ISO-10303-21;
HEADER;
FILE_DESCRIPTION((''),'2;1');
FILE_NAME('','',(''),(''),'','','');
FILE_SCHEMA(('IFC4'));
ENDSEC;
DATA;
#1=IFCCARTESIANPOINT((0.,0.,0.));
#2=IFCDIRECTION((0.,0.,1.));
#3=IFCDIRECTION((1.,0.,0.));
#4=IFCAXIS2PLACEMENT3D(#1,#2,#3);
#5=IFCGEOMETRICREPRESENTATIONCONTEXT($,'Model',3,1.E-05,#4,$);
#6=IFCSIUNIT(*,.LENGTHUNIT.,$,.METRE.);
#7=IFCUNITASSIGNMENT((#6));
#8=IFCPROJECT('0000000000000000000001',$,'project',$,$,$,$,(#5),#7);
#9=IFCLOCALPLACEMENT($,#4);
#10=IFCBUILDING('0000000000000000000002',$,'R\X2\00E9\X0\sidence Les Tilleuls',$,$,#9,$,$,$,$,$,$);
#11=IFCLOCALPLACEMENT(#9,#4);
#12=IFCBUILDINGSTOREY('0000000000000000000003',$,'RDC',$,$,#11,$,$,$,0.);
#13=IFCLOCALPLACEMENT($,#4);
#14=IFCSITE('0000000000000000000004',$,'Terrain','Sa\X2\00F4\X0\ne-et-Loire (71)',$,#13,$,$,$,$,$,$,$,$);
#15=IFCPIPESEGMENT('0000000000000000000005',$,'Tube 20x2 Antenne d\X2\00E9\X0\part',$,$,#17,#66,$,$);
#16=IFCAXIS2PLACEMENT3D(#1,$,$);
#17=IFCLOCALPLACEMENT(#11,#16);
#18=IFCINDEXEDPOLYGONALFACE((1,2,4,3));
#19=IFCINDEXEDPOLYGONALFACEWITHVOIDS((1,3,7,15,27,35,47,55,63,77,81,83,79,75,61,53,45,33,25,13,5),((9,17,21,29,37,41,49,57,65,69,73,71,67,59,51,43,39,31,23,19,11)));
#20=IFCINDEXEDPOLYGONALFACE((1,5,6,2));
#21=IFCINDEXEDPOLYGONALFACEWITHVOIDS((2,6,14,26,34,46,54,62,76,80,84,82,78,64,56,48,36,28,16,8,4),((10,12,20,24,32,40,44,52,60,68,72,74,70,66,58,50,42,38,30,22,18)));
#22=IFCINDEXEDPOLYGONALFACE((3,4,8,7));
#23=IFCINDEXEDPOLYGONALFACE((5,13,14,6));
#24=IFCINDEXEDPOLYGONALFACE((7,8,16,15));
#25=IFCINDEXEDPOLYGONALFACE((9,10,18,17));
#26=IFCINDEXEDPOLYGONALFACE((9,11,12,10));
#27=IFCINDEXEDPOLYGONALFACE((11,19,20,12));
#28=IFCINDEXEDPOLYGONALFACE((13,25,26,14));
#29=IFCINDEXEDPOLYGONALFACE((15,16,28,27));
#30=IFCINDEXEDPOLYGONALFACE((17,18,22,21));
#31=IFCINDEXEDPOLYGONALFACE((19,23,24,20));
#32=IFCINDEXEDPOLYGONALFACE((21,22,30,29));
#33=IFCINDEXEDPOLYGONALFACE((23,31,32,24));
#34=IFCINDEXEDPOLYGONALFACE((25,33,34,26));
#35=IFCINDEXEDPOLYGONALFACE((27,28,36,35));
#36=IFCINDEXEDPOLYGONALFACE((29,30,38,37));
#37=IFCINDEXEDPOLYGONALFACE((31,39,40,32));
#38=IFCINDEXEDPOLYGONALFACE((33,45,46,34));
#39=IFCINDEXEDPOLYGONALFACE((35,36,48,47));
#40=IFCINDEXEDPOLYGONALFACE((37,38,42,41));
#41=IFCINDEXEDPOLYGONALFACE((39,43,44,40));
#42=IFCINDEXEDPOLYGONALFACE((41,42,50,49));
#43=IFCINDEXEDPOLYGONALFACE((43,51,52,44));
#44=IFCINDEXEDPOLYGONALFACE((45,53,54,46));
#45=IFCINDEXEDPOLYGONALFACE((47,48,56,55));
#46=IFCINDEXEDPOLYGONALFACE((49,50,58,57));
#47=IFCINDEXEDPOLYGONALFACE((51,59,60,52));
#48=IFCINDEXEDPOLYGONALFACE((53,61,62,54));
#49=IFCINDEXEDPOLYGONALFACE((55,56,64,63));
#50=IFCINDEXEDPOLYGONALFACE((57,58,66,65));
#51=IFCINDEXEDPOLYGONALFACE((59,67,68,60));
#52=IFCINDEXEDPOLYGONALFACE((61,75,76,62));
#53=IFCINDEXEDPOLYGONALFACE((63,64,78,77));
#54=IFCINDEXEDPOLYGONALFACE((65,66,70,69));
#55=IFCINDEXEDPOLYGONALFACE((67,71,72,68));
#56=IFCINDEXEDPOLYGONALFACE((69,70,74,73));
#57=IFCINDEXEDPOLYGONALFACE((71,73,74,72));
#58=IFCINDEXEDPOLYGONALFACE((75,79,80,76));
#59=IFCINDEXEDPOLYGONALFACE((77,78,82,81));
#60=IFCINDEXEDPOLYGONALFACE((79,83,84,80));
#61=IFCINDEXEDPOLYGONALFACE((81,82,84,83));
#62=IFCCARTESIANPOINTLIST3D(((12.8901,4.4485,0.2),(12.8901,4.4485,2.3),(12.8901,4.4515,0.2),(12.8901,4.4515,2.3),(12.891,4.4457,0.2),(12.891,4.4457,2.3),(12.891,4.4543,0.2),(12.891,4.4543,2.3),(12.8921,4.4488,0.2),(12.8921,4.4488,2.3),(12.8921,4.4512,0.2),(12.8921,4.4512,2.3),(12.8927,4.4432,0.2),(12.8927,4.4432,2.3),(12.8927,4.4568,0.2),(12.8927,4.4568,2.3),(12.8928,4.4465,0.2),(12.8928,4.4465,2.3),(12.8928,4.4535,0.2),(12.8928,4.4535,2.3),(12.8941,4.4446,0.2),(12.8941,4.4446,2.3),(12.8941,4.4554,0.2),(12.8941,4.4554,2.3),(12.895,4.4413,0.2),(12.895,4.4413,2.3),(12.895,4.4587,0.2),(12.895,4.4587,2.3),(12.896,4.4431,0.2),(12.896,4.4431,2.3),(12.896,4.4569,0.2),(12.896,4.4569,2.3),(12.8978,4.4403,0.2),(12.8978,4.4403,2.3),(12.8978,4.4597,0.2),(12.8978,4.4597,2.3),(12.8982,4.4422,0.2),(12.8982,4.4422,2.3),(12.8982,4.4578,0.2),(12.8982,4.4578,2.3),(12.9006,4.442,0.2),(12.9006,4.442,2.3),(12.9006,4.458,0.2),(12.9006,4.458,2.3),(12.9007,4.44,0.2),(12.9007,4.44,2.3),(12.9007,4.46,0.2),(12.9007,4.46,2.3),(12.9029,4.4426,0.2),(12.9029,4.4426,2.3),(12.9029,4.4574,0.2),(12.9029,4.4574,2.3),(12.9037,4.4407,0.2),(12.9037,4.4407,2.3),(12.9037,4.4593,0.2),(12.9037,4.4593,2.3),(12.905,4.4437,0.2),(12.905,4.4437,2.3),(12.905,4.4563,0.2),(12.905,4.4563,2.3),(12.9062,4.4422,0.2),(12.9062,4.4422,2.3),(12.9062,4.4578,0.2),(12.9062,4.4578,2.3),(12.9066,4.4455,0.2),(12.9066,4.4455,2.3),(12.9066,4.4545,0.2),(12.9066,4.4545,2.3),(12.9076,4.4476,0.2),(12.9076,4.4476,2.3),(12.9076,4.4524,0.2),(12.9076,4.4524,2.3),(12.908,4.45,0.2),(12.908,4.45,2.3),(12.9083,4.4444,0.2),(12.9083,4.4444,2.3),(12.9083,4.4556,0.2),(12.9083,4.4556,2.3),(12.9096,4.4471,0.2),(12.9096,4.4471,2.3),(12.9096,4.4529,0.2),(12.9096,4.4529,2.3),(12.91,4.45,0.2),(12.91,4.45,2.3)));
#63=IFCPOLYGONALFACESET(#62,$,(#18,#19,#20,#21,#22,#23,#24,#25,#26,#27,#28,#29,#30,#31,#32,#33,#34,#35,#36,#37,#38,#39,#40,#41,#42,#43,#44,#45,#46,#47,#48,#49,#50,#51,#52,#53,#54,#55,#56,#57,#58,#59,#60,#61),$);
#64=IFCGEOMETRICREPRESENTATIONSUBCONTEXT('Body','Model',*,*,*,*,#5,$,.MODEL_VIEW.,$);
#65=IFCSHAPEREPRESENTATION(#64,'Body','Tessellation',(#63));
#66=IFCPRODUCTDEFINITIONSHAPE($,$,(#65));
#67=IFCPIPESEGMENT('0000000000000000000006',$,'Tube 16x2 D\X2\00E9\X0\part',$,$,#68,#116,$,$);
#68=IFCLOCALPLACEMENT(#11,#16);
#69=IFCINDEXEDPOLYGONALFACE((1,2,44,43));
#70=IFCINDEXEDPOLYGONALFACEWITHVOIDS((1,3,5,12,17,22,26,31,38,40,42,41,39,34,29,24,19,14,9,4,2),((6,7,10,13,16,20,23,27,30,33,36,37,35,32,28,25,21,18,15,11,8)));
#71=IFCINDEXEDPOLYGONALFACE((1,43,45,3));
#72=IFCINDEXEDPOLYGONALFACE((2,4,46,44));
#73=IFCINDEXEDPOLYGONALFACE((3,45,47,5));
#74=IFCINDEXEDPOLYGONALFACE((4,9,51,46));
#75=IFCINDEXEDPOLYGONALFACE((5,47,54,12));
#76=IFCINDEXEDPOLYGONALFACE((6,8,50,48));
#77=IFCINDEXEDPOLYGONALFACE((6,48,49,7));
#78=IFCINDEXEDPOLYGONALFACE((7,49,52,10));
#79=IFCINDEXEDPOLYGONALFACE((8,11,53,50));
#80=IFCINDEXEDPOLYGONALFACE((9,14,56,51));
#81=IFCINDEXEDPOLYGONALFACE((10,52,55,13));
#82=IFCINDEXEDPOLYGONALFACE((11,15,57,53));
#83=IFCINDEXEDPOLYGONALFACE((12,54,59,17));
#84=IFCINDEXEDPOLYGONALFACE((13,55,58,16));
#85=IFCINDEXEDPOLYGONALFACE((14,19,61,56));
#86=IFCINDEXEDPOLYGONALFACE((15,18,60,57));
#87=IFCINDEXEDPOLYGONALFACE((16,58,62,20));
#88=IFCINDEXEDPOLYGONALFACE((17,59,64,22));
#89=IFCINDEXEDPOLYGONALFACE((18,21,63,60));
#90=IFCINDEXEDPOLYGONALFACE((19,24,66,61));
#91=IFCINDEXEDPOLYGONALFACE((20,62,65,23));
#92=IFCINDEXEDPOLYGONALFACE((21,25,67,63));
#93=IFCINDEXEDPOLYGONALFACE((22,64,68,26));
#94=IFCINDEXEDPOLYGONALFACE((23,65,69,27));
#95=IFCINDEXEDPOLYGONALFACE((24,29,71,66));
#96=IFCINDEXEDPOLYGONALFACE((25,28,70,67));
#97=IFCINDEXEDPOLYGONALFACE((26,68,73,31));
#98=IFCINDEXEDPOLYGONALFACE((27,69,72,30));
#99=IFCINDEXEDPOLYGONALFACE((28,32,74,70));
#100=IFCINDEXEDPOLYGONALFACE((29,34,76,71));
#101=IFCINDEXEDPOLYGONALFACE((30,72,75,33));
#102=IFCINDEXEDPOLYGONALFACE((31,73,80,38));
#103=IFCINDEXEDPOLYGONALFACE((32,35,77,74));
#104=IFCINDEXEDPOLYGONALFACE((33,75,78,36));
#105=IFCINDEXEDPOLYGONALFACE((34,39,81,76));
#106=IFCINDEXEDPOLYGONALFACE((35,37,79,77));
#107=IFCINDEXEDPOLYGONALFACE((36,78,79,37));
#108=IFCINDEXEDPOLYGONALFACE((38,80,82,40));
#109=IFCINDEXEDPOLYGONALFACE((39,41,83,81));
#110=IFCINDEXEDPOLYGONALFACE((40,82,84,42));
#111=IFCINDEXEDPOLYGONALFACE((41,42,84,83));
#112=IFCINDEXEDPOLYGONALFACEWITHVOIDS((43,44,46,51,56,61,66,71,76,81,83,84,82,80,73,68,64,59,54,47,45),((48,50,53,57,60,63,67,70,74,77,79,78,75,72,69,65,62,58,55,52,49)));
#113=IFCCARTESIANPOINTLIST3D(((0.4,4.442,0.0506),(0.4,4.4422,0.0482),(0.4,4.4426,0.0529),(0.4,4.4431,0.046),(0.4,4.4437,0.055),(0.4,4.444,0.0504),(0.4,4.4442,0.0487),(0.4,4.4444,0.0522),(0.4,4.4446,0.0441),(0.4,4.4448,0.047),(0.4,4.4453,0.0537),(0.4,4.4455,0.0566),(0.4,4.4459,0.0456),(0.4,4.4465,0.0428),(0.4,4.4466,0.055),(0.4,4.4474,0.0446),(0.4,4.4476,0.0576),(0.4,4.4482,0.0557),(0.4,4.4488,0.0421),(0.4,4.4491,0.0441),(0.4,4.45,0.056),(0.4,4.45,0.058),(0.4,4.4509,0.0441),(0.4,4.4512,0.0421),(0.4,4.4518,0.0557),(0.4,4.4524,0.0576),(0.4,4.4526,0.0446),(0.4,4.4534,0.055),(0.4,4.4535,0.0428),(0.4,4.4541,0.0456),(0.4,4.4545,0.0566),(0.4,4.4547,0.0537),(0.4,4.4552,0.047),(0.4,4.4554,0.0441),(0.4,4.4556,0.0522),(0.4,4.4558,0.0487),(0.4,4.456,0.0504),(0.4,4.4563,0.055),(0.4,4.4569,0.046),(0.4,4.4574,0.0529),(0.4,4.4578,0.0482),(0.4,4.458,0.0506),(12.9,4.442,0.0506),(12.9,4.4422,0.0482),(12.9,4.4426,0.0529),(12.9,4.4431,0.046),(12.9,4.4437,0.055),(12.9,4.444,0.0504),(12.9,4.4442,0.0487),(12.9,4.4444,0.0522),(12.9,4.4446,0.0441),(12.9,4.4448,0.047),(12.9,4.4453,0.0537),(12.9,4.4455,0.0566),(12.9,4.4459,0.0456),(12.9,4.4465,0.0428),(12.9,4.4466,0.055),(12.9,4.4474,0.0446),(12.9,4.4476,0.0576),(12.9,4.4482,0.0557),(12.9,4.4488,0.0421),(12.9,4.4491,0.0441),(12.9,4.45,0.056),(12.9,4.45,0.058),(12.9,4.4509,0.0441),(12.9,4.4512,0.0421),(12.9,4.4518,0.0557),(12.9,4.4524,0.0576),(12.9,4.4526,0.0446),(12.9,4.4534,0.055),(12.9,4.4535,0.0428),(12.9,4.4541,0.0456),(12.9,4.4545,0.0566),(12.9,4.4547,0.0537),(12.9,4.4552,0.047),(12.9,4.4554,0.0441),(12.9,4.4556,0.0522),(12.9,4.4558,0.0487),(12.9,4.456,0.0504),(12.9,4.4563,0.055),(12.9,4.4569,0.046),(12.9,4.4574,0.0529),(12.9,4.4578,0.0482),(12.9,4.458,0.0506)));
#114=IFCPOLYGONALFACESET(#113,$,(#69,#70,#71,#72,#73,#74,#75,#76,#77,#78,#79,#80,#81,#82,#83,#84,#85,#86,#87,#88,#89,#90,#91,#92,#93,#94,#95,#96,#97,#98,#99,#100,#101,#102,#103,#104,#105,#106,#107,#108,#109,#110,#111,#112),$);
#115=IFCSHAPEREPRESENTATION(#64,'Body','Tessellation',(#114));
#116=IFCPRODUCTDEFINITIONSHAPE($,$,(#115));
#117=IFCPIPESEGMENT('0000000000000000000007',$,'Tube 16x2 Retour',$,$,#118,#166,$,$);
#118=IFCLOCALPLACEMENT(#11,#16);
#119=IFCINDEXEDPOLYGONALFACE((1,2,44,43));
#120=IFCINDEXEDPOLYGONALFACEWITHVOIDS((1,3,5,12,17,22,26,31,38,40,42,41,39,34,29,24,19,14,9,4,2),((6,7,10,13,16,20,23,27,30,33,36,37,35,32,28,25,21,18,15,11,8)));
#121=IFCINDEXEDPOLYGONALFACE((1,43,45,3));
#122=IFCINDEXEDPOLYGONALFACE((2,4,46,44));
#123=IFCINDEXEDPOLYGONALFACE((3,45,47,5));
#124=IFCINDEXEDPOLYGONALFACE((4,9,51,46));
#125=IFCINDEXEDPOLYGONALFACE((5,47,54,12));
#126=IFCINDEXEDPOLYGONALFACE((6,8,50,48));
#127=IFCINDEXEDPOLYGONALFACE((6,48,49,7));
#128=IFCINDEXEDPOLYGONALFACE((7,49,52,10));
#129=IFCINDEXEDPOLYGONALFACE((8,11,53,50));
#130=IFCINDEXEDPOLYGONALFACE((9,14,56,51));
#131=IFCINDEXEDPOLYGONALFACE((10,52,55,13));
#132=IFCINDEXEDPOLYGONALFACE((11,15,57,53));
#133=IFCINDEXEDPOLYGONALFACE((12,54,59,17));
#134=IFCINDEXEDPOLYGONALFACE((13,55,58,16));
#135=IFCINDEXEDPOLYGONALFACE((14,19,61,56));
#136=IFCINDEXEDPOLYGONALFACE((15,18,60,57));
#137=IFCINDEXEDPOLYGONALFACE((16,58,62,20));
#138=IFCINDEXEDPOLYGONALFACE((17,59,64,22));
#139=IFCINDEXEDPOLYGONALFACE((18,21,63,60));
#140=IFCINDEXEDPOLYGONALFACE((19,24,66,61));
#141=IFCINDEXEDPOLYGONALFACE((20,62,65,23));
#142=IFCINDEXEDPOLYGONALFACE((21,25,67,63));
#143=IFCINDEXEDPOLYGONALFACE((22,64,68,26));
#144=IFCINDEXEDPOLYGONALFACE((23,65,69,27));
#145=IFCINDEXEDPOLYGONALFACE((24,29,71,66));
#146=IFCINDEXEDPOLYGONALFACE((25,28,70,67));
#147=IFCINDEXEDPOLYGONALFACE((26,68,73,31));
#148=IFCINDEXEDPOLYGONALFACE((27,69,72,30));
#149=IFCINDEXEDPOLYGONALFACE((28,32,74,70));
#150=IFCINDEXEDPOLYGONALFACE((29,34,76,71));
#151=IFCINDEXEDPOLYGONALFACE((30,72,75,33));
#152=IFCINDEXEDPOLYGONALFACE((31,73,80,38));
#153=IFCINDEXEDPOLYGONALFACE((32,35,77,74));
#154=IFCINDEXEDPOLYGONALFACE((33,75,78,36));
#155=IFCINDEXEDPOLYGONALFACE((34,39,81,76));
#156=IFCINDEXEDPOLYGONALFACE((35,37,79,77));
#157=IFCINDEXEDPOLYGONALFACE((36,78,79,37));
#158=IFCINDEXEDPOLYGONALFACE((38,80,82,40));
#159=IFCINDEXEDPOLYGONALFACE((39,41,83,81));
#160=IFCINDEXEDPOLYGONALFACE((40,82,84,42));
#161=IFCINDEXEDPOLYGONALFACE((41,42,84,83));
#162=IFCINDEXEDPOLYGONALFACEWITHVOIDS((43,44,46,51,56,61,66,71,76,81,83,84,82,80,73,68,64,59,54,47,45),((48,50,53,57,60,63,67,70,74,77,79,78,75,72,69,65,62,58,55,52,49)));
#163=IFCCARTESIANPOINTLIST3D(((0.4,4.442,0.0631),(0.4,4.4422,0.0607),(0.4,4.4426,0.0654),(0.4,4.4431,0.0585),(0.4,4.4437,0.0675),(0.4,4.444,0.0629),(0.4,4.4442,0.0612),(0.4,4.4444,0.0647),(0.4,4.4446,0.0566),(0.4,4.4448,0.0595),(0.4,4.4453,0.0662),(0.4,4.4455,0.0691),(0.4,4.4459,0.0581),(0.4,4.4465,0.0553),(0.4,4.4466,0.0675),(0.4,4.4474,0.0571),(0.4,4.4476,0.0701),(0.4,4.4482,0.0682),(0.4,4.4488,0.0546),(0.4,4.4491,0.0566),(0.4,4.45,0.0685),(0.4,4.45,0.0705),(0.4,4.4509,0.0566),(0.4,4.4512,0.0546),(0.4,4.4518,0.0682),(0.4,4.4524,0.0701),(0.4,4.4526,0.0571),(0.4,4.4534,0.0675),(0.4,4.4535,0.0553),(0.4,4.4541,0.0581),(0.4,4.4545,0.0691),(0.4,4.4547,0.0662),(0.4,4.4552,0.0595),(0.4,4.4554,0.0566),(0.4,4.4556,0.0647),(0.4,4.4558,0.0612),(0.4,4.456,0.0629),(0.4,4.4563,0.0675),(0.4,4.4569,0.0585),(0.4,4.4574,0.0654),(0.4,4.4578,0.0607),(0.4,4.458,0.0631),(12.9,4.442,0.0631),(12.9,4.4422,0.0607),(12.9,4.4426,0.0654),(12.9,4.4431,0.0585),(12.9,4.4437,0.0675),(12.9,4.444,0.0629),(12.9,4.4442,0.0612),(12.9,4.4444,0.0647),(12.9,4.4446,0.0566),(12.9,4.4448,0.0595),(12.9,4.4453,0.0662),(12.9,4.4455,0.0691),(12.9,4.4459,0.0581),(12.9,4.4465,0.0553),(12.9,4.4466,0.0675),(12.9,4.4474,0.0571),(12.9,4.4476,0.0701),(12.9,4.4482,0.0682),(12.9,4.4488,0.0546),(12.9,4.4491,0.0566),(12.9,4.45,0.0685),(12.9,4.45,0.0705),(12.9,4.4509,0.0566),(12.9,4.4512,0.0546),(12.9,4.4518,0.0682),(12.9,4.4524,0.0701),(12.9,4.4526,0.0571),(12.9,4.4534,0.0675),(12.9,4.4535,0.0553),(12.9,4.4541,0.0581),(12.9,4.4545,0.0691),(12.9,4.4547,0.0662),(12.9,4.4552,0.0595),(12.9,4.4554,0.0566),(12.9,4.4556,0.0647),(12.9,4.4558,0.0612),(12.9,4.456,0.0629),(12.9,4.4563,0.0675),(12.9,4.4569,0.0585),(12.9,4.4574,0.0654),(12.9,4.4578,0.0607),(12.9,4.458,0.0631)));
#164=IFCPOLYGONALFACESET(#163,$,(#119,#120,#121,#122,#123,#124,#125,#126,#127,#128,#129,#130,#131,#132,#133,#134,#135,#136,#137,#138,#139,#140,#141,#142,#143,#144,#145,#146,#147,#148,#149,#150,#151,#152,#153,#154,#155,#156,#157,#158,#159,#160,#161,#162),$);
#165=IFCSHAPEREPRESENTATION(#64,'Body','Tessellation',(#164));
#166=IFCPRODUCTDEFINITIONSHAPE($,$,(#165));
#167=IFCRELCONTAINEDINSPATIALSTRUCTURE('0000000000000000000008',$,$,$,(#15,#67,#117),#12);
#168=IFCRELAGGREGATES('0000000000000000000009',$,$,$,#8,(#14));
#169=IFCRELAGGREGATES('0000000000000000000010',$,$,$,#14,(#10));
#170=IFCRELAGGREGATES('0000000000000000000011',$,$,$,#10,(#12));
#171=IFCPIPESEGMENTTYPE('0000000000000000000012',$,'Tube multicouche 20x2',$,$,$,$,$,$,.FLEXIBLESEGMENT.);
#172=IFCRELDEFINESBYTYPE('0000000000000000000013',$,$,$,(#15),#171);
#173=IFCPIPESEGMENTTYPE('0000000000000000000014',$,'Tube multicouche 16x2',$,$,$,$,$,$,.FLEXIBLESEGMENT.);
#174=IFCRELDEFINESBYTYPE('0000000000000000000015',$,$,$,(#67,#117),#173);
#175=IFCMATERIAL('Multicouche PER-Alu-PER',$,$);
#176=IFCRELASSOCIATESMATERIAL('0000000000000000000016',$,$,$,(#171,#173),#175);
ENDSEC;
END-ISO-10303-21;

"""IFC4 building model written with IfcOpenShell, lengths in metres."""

from ifc_helpers import new_model, si_unit, frame, origin_with_axes, place, context, subcontext, project, spatial, hollow_circle, extrude, material, type_object, element, save


model = new_model("IFC4")

# Units and contexts
model_context = context("Model", 3, precision=1e-05, world=origin_with_axes())
body_context = subcontext(model_context, "Body", "Model", "MODEL_VIEW")
ifc_project = project(units=[si_unit("LENGTHUNIT", "METRE")], contexts=[model_context])

# Site, building, storey
site_placement = place(None, origin_with_axes())
site = spatial("IfcSite", under=ifc_project, at=site_placement, Name="Terrain", Description="Saône-et-Loire (71)")
building_placement = place(None, origin_with_axes())
building = spatial("IfcBuilding", under=site, at=building_placement, Name="Résidence Les Tilleuls")
storey_placement = place(building_placement, origin_with_axes())
storey = spatial("IfcBuildingStorey", under=building, at=storey_placement, Name="RDC", Elevation=0.0)

# Pipe segments
ifc_material = material(Name="Multicouche PER-Alu-PER")
pipe_segment_type_1 = type_object("IfcPipeSegmentType", Name="Tube multicouche 20x2", PredefinedType="FLEXIBLESEGMENT", material=ifc_material)
pipe_segment_1_placement = place(storey_placement, frame((12.9, 4.45, 2.3), z_axis=(0.0, 0.0, -1.0), x_axis=(1.0, 0.0, 0.0)))
element("IfcPipeSegment", 1, at=pipe_segment_1_placement, inside=storey, type_object=pipe_segment_type_1, Name="Tube 20x2 Antenne départ", context=body_context, shape_type="SweptSolid", body=[
    extrude(hollow_circle(Radius=0.01, WallThickness=0.002), origin_with_axes(), (0.0, 0.0, 1.0), 2.1),
])
pipe_segment_type_2 = type_object("IfcPipeSegmentType", Name="Tube multicouche 16x2", PredefinedType="FLEXIBLESEGMENT", material=ifc_material)
for number, where, z_axis, x_axis, name in (
    (2, (12.9, 4.45, 0.05), (-1.0, 0.0, 0.0), (0.0, 0.0, 1.0), "Tube 16x2 Départ"),
    (3, (12.9, 4.45, 0.0625), (-1.0, 0.0, 0.0), (0.0, 0.0, 1.0), "Tube 16x2 Retour"),
):
    element("IfcPipeSegment", number, at=place(storey_placement, frame(where, z_axis=z_axis, x_axis=x_axis)), inside=storey, type_object=pipe_segment_type_2, Name=name, context=body_context, shape_type="SweptSolid", body=[
        extrude(hollow_circle(Radius=0.008, WallThickness=0.002), origin_with_axes(), (0.0, 0.0, 1.0), 12.5),
    ])

save(model, "model.ifc")
